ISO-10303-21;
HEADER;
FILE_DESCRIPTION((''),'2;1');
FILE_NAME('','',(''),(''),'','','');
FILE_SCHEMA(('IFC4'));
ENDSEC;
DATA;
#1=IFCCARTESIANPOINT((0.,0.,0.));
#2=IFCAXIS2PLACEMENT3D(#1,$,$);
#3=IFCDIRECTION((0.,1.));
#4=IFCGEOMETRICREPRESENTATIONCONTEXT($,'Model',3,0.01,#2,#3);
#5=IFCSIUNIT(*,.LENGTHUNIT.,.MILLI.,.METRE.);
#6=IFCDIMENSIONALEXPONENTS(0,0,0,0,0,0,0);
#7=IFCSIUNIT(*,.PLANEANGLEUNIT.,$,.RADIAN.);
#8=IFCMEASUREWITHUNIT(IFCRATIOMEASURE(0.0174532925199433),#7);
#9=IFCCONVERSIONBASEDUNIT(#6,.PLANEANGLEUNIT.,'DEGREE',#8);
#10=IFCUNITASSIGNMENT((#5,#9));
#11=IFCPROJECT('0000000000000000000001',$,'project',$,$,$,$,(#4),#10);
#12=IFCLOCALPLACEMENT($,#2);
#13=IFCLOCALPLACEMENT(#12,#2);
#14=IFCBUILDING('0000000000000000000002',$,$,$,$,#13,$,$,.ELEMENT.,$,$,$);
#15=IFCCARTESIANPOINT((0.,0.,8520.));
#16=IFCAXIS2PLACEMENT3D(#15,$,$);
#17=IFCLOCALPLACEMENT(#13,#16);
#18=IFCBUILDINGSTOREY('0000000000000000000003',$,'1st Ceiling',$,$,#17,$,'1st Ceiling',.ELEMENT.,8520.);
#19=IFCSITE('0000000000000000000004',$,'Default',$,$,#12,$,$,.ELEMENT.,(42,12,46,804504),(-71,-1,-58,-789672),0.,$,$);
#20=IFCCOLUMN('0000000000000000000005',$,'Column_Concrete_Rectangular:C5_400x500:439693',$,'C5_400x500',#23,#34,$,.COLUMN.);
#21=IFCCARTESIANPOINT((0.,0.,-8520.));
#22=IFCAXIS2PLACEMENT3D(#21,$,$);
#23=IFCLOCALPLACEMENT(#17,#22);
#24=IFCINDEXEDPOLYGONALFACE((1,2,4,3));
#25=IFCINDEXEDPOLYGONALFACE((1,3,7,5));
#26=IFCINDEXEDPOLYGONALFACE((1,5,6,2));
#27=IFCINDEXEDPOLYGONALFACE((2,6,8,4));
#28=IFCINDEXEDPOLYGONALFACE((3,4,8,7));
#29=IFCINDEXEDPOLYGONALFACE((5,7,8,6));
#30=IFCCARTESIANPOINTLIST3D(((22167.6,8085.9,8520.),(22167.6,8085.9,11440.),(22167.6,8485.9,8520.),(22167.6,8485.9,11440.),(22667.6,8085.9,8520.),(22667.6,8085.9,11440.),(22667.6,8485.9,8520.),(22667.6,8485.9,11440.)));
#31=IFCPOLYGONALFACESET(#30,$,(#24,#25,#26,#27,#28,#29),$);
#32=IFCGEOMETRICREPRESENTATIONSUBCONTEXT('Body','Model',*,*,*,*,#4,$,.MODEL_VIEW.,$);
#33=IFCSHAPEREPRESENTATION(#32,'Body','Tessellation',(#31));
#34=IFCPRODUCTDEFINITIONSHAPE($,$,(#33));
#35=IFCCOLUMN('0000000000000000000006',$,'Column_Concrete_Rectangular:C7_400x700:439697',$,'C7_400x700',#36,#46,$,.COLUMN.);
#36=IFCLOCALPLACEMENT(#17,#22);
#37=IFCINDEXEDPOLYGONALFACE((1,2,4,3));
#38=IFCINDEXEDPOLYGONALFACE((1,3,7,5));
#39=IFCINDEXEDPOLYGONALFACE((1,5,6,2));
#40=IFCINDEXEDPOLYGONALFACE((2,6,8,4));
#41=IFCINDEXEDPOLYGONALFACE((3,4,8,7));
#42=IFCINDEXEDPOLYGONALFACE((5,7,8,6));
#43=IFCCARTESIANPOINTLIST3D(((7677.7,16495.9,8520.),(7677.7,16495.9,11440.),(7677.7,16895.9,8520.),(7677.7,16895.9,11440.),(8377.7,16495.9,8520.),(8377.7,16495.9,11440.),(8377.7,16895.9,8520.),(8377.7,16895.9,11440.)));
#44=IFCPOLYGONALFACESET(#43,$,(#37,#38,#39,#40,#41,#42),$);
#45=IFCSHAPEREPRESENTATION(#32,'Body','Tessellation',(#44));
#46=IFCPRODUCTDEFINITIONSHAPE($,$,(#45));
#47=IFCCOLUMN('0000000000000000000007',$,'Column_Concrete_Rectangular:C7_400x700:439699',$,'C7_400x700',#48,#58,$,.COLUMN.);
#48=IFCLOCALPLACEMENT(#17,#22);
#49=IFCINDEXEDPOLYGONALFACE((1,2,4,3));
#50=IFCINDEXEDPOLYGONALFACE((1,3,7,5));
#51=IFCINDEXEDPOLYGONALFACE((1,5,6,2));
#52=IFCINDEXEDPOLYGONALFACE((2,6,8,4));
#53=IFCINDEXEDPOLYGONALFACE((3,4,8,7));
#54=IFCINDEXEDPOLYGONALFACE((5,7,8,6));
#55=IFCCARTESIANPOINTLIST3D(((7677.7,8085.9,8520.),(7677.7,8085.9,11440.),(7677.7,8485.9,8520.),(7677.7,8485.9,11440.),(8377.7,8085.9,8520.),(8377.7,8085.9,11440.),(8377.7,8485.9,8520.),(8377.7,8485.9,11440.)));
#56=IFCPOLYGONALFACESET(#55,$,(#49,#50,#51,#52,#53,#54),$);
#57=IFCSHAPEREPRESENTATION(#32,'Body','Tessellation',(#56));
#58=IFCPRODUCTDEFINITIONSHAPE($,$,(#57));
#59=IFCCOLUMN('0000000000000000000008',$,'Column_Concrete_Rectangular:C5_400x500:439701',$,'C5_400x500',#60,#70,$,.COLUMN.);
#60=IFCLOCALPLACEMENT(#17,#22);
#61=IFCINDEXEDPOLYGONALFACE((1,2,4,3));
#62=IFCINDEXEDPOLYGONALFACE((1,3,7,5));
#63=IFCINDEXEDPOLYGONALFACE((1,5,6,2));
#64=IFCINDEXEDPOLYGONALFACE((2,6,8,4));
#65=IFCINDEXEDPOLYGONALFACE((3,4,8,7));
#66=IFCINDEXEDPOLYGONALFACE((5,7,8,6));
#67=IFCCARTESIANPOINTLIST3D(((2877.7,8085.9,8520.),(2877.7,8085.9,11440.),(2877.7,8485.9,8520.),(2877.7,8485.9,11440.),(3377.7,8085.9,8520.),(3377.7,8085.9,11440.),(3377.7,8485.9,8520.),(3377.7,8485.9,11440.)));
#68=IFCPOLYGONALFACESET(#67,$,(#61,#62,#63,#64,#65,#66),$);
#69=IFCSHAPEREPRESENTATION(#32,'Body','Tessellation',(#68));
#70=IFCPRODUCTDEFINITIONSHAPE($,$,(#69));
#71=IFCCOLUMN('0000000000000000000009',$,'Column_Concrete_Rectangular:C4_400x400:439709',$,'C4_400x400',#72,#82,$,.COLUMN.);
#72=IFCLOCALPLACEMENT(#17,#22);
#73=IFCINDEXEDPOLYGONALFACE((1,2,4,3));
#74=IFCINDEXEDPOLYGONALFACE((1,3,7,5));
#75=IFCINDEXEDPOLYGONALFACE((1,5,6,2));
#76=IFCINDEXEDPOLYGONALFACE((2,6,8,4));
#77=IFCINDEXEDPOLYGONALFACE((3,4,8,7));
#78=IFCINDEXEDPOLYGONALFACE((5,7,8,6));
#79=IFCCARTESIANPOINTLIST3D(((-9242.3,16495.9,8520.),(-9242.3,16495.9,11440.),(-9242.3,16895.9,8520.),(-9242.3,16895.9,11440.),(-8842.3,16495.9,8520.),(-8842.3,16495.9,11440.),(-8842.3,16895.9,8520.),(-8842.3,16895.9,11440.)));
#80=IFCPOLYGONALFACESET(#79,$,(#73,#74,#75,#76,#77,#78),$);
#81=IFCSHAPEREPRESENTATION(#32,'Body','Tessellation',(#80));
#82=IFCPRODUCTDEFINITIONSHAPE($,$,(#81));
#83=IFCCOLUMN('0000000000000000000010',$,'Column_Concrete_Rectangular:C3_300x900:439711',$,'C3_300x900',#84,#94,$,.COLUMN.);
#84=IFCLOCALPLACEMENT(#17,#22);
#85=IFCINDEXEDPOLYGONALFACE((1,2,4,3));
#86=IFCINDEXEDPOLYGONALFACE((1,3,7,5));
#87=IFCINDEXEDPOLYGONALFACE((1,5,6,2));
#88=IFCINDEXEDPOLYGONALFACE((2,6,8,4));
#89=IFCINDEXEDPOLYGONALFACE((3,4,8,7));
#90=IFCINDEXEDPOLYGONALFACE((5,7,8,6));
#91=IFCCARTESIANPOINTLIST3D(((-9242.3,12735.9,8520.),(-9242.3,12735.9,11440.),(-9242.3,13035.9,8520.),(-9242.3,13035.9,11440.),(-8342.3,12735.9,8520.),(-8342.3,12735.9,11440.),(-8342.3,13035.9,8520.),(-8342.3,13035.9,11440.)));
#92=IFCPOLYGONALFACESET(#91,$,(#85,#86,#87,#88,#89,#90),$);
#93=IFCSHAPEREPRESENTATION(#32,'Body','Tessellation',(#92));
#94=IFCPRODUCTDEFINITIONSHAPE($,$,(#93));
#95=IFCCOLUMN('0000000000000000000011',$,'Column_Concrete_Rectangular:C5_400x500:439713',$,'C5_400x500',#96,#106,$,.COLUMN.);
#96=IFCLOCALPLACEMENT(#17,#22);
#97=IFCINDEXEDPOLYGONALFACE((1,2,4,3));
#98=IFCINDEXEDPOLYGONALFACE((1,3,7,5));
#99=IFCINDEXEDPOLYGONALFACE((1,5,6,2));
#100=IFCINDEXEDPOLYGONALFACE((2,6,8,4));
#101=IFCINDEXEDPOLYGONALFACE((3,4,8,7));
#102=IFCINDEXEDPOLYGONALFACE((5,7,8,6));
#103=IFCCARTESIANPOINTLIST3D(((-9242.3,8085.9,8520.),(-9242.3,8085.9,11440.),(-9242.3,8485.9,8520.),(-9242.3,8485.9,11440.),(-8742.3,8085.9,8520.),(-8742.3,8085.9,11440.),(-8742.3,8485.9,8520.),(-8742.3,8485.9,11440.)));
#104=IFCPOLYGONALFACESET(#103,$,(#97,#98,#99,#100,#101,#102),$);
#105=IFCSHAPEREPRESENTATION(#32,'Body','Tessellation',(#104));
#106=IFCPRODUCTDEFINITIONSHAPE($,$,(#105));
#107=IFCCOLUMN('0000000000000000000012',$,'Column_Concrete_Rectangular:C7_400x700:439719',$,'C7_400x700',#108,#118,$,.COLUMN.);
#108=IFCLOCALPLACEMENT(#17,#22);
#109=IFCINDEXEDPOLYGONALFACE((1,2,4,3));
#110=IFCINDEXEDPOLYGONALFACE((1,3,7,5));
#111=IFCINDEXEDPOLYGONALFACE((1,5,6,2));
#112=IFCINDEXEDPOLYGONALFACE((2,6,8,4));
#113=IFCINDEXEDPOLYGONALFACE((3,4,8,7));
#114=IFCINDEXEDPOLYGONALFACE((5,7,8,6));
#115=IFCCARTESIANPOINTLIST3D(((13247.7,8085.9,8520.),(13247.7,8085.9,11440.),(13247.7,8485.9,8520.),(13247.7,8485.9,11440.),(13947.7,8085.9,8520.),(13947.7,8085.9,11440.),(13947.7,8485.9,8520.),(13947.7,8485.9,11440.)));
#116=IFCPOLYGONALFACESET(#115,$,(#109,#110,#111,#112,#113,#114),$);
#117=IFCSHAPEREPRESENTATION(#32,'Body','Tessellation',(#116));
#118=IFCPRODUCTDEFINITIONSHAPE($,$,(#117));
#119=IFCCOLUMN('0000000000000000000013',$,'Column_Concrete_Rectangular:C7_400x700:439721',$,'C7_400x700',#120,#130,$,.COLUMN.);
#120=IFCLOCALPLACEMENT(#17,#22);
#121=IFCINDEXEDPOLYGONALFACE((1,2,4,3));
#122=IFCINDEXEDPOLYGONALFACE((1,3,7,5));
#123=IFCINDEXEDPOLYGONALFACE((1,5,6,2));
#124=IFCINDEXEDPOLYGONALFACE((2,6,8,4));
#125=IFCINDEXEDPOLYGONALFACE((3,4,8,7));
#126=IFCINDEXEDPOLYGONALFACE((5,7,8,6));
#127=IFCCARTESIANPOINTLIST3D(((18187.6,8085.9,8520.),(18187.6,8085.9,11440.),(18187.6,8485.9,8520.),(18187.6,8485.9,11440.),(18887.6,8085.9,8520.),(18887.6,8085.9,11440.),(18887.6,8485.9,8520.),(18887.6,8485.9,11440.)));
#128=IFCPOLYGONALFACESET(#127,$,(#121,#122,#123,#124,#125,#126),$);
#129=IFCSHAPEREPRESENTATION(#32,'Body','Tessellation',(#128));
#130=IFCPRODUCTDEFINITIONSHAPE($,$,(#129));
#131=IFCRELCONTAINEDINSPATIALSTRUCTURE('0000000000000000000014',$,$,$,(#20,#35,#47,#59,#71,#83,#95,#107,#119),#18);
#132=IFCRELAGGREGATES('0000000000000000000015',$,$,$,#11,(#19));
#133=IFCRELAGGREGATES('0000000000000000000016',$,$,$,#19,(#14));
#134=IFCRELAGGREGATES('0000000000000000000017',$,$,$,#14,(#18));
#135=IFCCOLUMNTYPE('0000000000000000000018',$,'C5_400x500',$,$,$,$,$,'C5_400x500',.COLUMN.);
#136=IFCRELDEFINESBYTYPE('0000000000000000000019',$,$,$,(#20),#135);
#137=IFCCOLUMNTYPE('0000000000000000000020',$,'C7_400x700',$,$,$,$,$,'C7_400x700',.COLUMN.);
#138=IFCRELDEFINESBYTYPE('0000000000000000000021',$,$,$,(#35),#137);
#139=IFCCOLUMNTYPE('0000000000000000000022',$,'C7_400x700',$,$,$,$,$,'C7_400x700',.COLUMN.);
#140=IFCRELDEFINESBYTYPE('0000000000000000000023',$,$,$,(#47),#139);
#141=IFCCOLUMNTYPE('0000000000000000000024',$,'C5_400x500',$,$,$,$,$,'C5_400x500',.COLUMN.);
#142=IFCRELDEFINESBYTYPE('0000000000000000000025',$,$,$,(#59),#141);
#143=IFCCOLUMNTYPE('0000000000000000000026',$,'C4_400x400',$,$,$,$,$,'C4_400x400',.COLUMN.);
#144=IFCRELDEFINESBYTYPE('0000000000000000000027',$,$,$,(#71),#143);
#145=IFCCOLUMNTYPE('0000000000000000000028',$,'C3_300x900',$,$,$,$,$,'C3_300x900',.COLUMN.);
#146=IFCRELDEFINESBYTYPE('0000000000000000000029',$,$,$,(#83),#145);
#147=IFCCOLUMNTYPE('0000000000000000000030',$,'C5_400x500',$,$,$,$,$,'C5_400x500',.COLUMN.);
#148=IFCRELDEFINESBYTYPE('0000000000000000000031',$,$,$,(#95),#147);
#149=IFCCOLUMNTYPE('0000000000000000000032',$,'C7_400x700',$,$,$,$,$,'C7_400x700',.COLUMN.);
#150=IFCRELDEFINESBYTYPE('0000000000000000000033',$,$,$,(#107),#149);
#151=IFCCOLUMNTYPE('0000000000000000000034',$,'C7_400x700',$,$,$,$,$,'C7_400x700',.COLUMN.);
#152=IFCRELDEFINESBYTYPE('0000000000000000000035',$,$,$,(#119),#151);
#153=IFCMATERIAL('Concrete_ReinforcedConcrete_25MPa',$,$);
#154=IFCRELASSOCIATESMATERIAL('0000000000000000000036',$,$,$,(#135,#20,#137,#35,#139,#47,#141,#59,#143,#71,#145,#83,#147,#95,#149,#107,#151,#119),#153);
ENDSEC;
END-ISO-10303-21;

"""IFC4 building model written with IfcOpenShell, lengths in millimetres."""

from ifc_helpers import new_model, entity, si_unit, converted_unit, direction, frame, frame_2d, origin, origin_2d_with_axis, place, context, subcontext, project, spatial, rectangle, extrude, source, transform, mapped, material, type_object, type_shapes, element, save


model = new_model("IFC4")

# Units and contexts
model_context = context("Model", 3, precision=0.01, world=origin(), true_north=direction((0.0, 1.0)))
body_context = subcontext(model_context, "Body", "Model", "MODEL_VIEW")
ifc_project = project(units=[si_unit("LENGTHUNIT", "METRE", prefix="MILLI"), converted_unit("PLANEANGLEUNIT", "DEGREE", entity("IfcRatioMeasure", 0.0174532925199433), si_unit("PLANEANGLEUNIT", "RADIAN"), dimensions=[0, 0, 0, 0, 0, 0, 0])], contexts=[model_context])

# Site, building, storey
site_placement = place(None, origin())
site = spatial("IfcSite", under=ifc_project, at=site_placement, Name="Default", CompositionType="ELEMENT", RefLatitude=(42, 12, 46, 804504), RefLongitude=(-71, -1, -58, -789672), RefElevation=0.0)
building_placement = place(site_placement, origin())
building = spatial("IfcBuilding", under=site, at=building_placement, CompositionType="ELEMENT")
storey_placement = place(building_placement, frame((0.0, 0.0, 8520.0)))
storey = spatial("IfcBuildingStorey", under=building, at=storey_placement, Name="1st Ceiling", LongName="1st Ceiling", CompositionType="ELEMENT", Elevation=8520.0)

# Columns
ifc_material = material(Name="Concrete_ReinforcedConcrete_25MPa")
column_type_1 = type_object("IfcColumnType", Name="C5_400x500", ElementType="C5_400x500", PredefinedType="COLUMN", material=ifc_material)
shared_shape_1 = source(origin(), body_context, "Body", "SweptSolid", [
    extrude(rectangle(XDim=400.0, YDim=500.0, at=frame_2d((0.0, 0.0), x_axis=(1.0, 0.0))), frame((22417.6, 8285.9, 8520.0), z_axis=(0.0, 0.0, 1.0), x_axis=(0.0, -1.0, 0.0)), (0.0, 0.0, 1.0), 2920.0),
])
type_shapes(column_type_1, [shared_shape_1])
column_1_placement = place(storey_placement, frame((0.0, 0.0, -8520.0)))
element("IfcColumn", 1, at=column_1_placement, inside=storey, type_object=column_type_1, material=ifc_material, Name="Column_Concrete_Rectangular:C5_400x500:439693", ObjectType="C5_400x500", PredefinedType="COLUMN", context=body_context, shape_type="MappedRepresentation", body=[
    mapped(shared_shape_1, transform((0.0, 0.0, 0.0), scale=1.0)),
])
column_type_2 = type_object("IfcColumnType", Name="C7_400x700", ElementType="C7_400x700", PredefinedType="COLUMN", material=ifc_material)
shared_shape_2 = source(origin(), body_context, "Body", "SweptSolid", [
    extrude(rectangle(XDim=400.0, YDim=700.0, at=frame_2d((0.0, 0.0), x_axis=(1.0, 0.0))), frame((8027.7, 16695.9, 8520.0), z_axis=(0.0, 0.0, 1.0), x_axis=(0.0, -1.0, 0.0)), (0.0, 0.0, 1.0), 2920.0),
])
type_shapes(column_type_2, [shared_shape_2])
column_2_placement = place(storey_placement, frame((0.0, 0.0, -8520.0)))
element("IfcColumn", 2, at=column_2_placement, inside=storey, type_object=column_type_2, material=ifc_material, Name="Column_Concrete_Rectangular:C7_400x700:439697", ObjectType="C7_400x700", PredefinedType="COLUMN", context=body_context, shape_type="MappedRepresentation", body=[
    mapped(shared_shape_2, transform((0.0, 0.0, 0.0), scale=1.0)),
])
column_type_3 = type_object("IfcColumnType", Name="C7_400x700", ElementType="C7_400x700", PredefinedType="COLUMN", material=ifc_material)
shared_shape_3 = source(origin(), body_context, "Body", "SweptSolid", [
    extrude(rectangle(XDim=400.0, YDim=700.0, at=origin_2d_with_axis()), frame((8027.7, 8285.9, 8520.0), z_axis=(0.0, 0.0, 1.0), x_axis=(0.0, -1.0, 0.0)), (0.0, 0.0, 1.0), 2920.0),
])
type_shapes(column_type_3, [shared_shape_3])
column_3_placement = place(storey_placement, frame((0.0, 0.0, -8520.0)))
element("IfcColumn", 3, at=column_3_placement, inside=storey, type_object=column_type_3, material=ifc_material, Name="Column_Concrete_Rectangular:C7_400x700:439699", ObjectType="C7_400x700", PredefinedType="COLUMN", context=body_context, shape_type="MappedRepresentation", body=[
    mapped(shared_shape_3, transform((0.0, 0.0, 0.0), scale=1.0)),
])
column_type_4 = type_object("IfcColumnType", Name="C5_400x500", ElementType="C5_400x500", PredefinedType="COLUMN", material=ifc_material)
shared_shape_4 = source(origin(), body_context, "Body", "SweptSolid", [
    extrude(rectangle(XDim=400.0, YDim=500.0, at=origin_2d_with_axis()), frame((3127.7, 8285.9, 8520.0), z_axis=(0.0, 0.0, 1.0), x_axis=(0.0, -1.0, 0.0)), (0.0, 0.0, 1.0), 2920.0),
])
type_shapes(column_type_4, [shared_shape_4])
column_4_placement = place(storey_placement, frame((0.0, 0.0, -8520.0)))
element("IfcColumn", 4, at=column_4_placement, inside=storey, type_object=column_type_4, material=ifc_material, Name="Column_Concrete_Rectangular:C5_400x500:439701", ObjectType="C5_400x500", PredefinedType="COLUMN", context=body_context, shape_type="MappedRepresentation", body=[
    mapped(shared_shape_4, transform((0.0, 0.0, 0.0), scale=1.0)),
])
column_type_5 = type_object("IfcColumnType", Name="C4_400x400", ElementType="C4_400x400", PredefinedType="COLUMN", material=ifc_material)
shared_shape_5 = source(origin(), body_context, "Body", "SweptSolid", [
    extrude(rectangle(XDim=400.0, YDim=400.0, at=origin_2d_with_axis()), frame((-9042.3, 16695.9, 8520.0), z_axis=(0.0, 0.0, 1.0), x_axis=(0.0, -1.0, 0.0)), (0.0, 0.0, 1.0), 2920.0),
])
type_shapes(column_type_5, [shared_shape_5])
column_5_placement = place(storey_placement, frame((0.0, 0.0, -8520.0)))
element("IfcColumn", 5, at=column_5_placement, inside=storey, type_object=column_type_5, material=ifc_material, Name="Column_Concrete_Rectangular:C4_400x400:439709", ObjectType="C4_400x400", PredefinedType="COLUMN", context=body_context, shape_type="MappedRepresentation", body=[
    mapped(shared_shape_5, transform((0.0, 0.0, 0.0), scale=1.0)),
])
column_type_6 = type_object("IfcColumnType", Name="C3_300x900", ElementType="C3_300x900", PredefinedType="COLUMN", material=ifc_material)
shared_shape_6 = source(origin(), body_context, "Body", "SweptSolid", [
    extrude(rectangle(XDim=300.0, YDim=900.0, at=frame_2d((0.0, 0.0), x_axis=(1.0, 0.0))), frame((-8792.3, 12885.9, 8520.0), z_axis=(0.0, 0.0, 1.0), x_axis=(0.0, -1.0, 0.0)), (0.0, 0.0, 1.0), 2920.0),
])
type_shapes(column_type_6, [shared_shape_6])
column_6_placement = place(storey_placement, frame((0.0, 0.0, -8520.0)))
element("IfcColumn", 6, at=column_6_placement, inside=storey, type_object=column_type_6, material=ifc_material, Name="Column_Concrete_Rectangular:C3_300x900:439711", ObjectType="C3_300x900", PredefinedType="COLUMN", context=body_context, shape_type="MappedRepresentation", body=[
    mapped(shared_shape_6, transform((0.0, 0.0, 0.0), scale=1.0)),
])
column_type_7 = type_object("IfcColumnType", Name="C5_400x500", ElementType="C5_400x500", PredefinedType="COLUMN", material=ifc_material)
shared_shape_7 = source(origin(), body_context, "Body", "SweptSolid", [
    extrude(rectangle(XDim=400.0, YDim=500.0, at=frame_2d((0.0, 0.0), x_axis=(1.0, 0.0))), frame((-8992.3, 8285.9, 8520.0), z_axis=(0.0, 0.0, 1.0), x_axis=(0.0, -1.0, 0.0)), (0.0, 0.0, 1.0), 2920.0),
])
type_shapes(column_type_7, [shared_shape_7])
column_7_placement = place(storey_placement, frame((0.0, 0.0, -8520.0)))
element("IfcColumn", 7, at=column_7_placement, inside=storey, type_object=column_type_7, material=ifc_material, Name="Column_Concrete_Rectangular:C5_400x500:439713", ObjectType="C5_400x500", PredefinedType="COLUMN", context=body_context, shape_type="MappedRepresentation", body=[
    mapped(shared_shape_7, transform((0.0, 0.0, 0.0), scale=1.0)),
])
column_type_8 = type_object("IfcColumnType", Name="C7_400x700", ElementType="C7_400x700", PredefinedType="COLUMN", material=ifc_material)
shared_shape_8 = source(origin(), body_context, "Body", "SweptSolid", [
    extrude(rectangle(XDim=400.0, YDim=700.0, at=frame_2d((0.0, 0.0), x_axis=(1.0, 0.0))), frame((13597.7, 8285.9, 8520.0), z_axis=(0.0, 0.0, 1.0), x_axis=(0.0, -1.0, 0.0)), (0.0, 0.0, 1.0), 2920.0),
])
type_shapes(column_type_8, [shared_shape_8])
column_8_placement = place(storey_placement, frame((0.0, 0.0, -8520.0)))
element("IfcColumn", 8, at=column_8_placement, inside=storey, type_object=column_type_8, material=ifc_material, Name="Column_Concrete_Rectangular:C7_400x700:439719", ObjectType="C7_400x700", PredefinedType="COLUMN", context=body_context, shape_type="MappedRepresentation", body=[
    mapped(shared_shape_8, transform((0.0, 0.0, 0.0), scale=1.0)),
])
column_type_9 = type_object("IfcColumnType", Name="C7_400x700", ElementType="C7_400x700", PredefinedType="COLUMN", material=ifc_material)
shared_shape_9 = source(origin(), body_context, "Body", "SweptSolid", [
    extrude(rectangle(XDim=400.0, YDim=700.0, at=origin_2d_with_axis()), frame((18537.6, 8285.9, 8520.0), z_axis=(0.0, 0.0, 1.0), x_axis=(0.0, -1.0, 0.0)), (0.0, 0.0, 1.0), 2920.0),
])
type_shapes(column_type_9, [shared_shape_9])
column_9_placement = place(storey_placement, frame((0.0, 0.0, -8520.0)))
element("IfcColumn", 9, at=column_9_placement, inside=storey, type_object=column_type_9, material=ifc_material, Name="Column_Concrete_Rectangular:C7_400x700:439721", ObjectType="C7_400x700", PredefinedType="COLUMN", context=body_context, shape_type="MappedRepresentation", body=[
    mapped(shared_shape_9, transform((0.0, 0.0, 0.0), scale=1.0)),
])

save(model, "model.ifc")
